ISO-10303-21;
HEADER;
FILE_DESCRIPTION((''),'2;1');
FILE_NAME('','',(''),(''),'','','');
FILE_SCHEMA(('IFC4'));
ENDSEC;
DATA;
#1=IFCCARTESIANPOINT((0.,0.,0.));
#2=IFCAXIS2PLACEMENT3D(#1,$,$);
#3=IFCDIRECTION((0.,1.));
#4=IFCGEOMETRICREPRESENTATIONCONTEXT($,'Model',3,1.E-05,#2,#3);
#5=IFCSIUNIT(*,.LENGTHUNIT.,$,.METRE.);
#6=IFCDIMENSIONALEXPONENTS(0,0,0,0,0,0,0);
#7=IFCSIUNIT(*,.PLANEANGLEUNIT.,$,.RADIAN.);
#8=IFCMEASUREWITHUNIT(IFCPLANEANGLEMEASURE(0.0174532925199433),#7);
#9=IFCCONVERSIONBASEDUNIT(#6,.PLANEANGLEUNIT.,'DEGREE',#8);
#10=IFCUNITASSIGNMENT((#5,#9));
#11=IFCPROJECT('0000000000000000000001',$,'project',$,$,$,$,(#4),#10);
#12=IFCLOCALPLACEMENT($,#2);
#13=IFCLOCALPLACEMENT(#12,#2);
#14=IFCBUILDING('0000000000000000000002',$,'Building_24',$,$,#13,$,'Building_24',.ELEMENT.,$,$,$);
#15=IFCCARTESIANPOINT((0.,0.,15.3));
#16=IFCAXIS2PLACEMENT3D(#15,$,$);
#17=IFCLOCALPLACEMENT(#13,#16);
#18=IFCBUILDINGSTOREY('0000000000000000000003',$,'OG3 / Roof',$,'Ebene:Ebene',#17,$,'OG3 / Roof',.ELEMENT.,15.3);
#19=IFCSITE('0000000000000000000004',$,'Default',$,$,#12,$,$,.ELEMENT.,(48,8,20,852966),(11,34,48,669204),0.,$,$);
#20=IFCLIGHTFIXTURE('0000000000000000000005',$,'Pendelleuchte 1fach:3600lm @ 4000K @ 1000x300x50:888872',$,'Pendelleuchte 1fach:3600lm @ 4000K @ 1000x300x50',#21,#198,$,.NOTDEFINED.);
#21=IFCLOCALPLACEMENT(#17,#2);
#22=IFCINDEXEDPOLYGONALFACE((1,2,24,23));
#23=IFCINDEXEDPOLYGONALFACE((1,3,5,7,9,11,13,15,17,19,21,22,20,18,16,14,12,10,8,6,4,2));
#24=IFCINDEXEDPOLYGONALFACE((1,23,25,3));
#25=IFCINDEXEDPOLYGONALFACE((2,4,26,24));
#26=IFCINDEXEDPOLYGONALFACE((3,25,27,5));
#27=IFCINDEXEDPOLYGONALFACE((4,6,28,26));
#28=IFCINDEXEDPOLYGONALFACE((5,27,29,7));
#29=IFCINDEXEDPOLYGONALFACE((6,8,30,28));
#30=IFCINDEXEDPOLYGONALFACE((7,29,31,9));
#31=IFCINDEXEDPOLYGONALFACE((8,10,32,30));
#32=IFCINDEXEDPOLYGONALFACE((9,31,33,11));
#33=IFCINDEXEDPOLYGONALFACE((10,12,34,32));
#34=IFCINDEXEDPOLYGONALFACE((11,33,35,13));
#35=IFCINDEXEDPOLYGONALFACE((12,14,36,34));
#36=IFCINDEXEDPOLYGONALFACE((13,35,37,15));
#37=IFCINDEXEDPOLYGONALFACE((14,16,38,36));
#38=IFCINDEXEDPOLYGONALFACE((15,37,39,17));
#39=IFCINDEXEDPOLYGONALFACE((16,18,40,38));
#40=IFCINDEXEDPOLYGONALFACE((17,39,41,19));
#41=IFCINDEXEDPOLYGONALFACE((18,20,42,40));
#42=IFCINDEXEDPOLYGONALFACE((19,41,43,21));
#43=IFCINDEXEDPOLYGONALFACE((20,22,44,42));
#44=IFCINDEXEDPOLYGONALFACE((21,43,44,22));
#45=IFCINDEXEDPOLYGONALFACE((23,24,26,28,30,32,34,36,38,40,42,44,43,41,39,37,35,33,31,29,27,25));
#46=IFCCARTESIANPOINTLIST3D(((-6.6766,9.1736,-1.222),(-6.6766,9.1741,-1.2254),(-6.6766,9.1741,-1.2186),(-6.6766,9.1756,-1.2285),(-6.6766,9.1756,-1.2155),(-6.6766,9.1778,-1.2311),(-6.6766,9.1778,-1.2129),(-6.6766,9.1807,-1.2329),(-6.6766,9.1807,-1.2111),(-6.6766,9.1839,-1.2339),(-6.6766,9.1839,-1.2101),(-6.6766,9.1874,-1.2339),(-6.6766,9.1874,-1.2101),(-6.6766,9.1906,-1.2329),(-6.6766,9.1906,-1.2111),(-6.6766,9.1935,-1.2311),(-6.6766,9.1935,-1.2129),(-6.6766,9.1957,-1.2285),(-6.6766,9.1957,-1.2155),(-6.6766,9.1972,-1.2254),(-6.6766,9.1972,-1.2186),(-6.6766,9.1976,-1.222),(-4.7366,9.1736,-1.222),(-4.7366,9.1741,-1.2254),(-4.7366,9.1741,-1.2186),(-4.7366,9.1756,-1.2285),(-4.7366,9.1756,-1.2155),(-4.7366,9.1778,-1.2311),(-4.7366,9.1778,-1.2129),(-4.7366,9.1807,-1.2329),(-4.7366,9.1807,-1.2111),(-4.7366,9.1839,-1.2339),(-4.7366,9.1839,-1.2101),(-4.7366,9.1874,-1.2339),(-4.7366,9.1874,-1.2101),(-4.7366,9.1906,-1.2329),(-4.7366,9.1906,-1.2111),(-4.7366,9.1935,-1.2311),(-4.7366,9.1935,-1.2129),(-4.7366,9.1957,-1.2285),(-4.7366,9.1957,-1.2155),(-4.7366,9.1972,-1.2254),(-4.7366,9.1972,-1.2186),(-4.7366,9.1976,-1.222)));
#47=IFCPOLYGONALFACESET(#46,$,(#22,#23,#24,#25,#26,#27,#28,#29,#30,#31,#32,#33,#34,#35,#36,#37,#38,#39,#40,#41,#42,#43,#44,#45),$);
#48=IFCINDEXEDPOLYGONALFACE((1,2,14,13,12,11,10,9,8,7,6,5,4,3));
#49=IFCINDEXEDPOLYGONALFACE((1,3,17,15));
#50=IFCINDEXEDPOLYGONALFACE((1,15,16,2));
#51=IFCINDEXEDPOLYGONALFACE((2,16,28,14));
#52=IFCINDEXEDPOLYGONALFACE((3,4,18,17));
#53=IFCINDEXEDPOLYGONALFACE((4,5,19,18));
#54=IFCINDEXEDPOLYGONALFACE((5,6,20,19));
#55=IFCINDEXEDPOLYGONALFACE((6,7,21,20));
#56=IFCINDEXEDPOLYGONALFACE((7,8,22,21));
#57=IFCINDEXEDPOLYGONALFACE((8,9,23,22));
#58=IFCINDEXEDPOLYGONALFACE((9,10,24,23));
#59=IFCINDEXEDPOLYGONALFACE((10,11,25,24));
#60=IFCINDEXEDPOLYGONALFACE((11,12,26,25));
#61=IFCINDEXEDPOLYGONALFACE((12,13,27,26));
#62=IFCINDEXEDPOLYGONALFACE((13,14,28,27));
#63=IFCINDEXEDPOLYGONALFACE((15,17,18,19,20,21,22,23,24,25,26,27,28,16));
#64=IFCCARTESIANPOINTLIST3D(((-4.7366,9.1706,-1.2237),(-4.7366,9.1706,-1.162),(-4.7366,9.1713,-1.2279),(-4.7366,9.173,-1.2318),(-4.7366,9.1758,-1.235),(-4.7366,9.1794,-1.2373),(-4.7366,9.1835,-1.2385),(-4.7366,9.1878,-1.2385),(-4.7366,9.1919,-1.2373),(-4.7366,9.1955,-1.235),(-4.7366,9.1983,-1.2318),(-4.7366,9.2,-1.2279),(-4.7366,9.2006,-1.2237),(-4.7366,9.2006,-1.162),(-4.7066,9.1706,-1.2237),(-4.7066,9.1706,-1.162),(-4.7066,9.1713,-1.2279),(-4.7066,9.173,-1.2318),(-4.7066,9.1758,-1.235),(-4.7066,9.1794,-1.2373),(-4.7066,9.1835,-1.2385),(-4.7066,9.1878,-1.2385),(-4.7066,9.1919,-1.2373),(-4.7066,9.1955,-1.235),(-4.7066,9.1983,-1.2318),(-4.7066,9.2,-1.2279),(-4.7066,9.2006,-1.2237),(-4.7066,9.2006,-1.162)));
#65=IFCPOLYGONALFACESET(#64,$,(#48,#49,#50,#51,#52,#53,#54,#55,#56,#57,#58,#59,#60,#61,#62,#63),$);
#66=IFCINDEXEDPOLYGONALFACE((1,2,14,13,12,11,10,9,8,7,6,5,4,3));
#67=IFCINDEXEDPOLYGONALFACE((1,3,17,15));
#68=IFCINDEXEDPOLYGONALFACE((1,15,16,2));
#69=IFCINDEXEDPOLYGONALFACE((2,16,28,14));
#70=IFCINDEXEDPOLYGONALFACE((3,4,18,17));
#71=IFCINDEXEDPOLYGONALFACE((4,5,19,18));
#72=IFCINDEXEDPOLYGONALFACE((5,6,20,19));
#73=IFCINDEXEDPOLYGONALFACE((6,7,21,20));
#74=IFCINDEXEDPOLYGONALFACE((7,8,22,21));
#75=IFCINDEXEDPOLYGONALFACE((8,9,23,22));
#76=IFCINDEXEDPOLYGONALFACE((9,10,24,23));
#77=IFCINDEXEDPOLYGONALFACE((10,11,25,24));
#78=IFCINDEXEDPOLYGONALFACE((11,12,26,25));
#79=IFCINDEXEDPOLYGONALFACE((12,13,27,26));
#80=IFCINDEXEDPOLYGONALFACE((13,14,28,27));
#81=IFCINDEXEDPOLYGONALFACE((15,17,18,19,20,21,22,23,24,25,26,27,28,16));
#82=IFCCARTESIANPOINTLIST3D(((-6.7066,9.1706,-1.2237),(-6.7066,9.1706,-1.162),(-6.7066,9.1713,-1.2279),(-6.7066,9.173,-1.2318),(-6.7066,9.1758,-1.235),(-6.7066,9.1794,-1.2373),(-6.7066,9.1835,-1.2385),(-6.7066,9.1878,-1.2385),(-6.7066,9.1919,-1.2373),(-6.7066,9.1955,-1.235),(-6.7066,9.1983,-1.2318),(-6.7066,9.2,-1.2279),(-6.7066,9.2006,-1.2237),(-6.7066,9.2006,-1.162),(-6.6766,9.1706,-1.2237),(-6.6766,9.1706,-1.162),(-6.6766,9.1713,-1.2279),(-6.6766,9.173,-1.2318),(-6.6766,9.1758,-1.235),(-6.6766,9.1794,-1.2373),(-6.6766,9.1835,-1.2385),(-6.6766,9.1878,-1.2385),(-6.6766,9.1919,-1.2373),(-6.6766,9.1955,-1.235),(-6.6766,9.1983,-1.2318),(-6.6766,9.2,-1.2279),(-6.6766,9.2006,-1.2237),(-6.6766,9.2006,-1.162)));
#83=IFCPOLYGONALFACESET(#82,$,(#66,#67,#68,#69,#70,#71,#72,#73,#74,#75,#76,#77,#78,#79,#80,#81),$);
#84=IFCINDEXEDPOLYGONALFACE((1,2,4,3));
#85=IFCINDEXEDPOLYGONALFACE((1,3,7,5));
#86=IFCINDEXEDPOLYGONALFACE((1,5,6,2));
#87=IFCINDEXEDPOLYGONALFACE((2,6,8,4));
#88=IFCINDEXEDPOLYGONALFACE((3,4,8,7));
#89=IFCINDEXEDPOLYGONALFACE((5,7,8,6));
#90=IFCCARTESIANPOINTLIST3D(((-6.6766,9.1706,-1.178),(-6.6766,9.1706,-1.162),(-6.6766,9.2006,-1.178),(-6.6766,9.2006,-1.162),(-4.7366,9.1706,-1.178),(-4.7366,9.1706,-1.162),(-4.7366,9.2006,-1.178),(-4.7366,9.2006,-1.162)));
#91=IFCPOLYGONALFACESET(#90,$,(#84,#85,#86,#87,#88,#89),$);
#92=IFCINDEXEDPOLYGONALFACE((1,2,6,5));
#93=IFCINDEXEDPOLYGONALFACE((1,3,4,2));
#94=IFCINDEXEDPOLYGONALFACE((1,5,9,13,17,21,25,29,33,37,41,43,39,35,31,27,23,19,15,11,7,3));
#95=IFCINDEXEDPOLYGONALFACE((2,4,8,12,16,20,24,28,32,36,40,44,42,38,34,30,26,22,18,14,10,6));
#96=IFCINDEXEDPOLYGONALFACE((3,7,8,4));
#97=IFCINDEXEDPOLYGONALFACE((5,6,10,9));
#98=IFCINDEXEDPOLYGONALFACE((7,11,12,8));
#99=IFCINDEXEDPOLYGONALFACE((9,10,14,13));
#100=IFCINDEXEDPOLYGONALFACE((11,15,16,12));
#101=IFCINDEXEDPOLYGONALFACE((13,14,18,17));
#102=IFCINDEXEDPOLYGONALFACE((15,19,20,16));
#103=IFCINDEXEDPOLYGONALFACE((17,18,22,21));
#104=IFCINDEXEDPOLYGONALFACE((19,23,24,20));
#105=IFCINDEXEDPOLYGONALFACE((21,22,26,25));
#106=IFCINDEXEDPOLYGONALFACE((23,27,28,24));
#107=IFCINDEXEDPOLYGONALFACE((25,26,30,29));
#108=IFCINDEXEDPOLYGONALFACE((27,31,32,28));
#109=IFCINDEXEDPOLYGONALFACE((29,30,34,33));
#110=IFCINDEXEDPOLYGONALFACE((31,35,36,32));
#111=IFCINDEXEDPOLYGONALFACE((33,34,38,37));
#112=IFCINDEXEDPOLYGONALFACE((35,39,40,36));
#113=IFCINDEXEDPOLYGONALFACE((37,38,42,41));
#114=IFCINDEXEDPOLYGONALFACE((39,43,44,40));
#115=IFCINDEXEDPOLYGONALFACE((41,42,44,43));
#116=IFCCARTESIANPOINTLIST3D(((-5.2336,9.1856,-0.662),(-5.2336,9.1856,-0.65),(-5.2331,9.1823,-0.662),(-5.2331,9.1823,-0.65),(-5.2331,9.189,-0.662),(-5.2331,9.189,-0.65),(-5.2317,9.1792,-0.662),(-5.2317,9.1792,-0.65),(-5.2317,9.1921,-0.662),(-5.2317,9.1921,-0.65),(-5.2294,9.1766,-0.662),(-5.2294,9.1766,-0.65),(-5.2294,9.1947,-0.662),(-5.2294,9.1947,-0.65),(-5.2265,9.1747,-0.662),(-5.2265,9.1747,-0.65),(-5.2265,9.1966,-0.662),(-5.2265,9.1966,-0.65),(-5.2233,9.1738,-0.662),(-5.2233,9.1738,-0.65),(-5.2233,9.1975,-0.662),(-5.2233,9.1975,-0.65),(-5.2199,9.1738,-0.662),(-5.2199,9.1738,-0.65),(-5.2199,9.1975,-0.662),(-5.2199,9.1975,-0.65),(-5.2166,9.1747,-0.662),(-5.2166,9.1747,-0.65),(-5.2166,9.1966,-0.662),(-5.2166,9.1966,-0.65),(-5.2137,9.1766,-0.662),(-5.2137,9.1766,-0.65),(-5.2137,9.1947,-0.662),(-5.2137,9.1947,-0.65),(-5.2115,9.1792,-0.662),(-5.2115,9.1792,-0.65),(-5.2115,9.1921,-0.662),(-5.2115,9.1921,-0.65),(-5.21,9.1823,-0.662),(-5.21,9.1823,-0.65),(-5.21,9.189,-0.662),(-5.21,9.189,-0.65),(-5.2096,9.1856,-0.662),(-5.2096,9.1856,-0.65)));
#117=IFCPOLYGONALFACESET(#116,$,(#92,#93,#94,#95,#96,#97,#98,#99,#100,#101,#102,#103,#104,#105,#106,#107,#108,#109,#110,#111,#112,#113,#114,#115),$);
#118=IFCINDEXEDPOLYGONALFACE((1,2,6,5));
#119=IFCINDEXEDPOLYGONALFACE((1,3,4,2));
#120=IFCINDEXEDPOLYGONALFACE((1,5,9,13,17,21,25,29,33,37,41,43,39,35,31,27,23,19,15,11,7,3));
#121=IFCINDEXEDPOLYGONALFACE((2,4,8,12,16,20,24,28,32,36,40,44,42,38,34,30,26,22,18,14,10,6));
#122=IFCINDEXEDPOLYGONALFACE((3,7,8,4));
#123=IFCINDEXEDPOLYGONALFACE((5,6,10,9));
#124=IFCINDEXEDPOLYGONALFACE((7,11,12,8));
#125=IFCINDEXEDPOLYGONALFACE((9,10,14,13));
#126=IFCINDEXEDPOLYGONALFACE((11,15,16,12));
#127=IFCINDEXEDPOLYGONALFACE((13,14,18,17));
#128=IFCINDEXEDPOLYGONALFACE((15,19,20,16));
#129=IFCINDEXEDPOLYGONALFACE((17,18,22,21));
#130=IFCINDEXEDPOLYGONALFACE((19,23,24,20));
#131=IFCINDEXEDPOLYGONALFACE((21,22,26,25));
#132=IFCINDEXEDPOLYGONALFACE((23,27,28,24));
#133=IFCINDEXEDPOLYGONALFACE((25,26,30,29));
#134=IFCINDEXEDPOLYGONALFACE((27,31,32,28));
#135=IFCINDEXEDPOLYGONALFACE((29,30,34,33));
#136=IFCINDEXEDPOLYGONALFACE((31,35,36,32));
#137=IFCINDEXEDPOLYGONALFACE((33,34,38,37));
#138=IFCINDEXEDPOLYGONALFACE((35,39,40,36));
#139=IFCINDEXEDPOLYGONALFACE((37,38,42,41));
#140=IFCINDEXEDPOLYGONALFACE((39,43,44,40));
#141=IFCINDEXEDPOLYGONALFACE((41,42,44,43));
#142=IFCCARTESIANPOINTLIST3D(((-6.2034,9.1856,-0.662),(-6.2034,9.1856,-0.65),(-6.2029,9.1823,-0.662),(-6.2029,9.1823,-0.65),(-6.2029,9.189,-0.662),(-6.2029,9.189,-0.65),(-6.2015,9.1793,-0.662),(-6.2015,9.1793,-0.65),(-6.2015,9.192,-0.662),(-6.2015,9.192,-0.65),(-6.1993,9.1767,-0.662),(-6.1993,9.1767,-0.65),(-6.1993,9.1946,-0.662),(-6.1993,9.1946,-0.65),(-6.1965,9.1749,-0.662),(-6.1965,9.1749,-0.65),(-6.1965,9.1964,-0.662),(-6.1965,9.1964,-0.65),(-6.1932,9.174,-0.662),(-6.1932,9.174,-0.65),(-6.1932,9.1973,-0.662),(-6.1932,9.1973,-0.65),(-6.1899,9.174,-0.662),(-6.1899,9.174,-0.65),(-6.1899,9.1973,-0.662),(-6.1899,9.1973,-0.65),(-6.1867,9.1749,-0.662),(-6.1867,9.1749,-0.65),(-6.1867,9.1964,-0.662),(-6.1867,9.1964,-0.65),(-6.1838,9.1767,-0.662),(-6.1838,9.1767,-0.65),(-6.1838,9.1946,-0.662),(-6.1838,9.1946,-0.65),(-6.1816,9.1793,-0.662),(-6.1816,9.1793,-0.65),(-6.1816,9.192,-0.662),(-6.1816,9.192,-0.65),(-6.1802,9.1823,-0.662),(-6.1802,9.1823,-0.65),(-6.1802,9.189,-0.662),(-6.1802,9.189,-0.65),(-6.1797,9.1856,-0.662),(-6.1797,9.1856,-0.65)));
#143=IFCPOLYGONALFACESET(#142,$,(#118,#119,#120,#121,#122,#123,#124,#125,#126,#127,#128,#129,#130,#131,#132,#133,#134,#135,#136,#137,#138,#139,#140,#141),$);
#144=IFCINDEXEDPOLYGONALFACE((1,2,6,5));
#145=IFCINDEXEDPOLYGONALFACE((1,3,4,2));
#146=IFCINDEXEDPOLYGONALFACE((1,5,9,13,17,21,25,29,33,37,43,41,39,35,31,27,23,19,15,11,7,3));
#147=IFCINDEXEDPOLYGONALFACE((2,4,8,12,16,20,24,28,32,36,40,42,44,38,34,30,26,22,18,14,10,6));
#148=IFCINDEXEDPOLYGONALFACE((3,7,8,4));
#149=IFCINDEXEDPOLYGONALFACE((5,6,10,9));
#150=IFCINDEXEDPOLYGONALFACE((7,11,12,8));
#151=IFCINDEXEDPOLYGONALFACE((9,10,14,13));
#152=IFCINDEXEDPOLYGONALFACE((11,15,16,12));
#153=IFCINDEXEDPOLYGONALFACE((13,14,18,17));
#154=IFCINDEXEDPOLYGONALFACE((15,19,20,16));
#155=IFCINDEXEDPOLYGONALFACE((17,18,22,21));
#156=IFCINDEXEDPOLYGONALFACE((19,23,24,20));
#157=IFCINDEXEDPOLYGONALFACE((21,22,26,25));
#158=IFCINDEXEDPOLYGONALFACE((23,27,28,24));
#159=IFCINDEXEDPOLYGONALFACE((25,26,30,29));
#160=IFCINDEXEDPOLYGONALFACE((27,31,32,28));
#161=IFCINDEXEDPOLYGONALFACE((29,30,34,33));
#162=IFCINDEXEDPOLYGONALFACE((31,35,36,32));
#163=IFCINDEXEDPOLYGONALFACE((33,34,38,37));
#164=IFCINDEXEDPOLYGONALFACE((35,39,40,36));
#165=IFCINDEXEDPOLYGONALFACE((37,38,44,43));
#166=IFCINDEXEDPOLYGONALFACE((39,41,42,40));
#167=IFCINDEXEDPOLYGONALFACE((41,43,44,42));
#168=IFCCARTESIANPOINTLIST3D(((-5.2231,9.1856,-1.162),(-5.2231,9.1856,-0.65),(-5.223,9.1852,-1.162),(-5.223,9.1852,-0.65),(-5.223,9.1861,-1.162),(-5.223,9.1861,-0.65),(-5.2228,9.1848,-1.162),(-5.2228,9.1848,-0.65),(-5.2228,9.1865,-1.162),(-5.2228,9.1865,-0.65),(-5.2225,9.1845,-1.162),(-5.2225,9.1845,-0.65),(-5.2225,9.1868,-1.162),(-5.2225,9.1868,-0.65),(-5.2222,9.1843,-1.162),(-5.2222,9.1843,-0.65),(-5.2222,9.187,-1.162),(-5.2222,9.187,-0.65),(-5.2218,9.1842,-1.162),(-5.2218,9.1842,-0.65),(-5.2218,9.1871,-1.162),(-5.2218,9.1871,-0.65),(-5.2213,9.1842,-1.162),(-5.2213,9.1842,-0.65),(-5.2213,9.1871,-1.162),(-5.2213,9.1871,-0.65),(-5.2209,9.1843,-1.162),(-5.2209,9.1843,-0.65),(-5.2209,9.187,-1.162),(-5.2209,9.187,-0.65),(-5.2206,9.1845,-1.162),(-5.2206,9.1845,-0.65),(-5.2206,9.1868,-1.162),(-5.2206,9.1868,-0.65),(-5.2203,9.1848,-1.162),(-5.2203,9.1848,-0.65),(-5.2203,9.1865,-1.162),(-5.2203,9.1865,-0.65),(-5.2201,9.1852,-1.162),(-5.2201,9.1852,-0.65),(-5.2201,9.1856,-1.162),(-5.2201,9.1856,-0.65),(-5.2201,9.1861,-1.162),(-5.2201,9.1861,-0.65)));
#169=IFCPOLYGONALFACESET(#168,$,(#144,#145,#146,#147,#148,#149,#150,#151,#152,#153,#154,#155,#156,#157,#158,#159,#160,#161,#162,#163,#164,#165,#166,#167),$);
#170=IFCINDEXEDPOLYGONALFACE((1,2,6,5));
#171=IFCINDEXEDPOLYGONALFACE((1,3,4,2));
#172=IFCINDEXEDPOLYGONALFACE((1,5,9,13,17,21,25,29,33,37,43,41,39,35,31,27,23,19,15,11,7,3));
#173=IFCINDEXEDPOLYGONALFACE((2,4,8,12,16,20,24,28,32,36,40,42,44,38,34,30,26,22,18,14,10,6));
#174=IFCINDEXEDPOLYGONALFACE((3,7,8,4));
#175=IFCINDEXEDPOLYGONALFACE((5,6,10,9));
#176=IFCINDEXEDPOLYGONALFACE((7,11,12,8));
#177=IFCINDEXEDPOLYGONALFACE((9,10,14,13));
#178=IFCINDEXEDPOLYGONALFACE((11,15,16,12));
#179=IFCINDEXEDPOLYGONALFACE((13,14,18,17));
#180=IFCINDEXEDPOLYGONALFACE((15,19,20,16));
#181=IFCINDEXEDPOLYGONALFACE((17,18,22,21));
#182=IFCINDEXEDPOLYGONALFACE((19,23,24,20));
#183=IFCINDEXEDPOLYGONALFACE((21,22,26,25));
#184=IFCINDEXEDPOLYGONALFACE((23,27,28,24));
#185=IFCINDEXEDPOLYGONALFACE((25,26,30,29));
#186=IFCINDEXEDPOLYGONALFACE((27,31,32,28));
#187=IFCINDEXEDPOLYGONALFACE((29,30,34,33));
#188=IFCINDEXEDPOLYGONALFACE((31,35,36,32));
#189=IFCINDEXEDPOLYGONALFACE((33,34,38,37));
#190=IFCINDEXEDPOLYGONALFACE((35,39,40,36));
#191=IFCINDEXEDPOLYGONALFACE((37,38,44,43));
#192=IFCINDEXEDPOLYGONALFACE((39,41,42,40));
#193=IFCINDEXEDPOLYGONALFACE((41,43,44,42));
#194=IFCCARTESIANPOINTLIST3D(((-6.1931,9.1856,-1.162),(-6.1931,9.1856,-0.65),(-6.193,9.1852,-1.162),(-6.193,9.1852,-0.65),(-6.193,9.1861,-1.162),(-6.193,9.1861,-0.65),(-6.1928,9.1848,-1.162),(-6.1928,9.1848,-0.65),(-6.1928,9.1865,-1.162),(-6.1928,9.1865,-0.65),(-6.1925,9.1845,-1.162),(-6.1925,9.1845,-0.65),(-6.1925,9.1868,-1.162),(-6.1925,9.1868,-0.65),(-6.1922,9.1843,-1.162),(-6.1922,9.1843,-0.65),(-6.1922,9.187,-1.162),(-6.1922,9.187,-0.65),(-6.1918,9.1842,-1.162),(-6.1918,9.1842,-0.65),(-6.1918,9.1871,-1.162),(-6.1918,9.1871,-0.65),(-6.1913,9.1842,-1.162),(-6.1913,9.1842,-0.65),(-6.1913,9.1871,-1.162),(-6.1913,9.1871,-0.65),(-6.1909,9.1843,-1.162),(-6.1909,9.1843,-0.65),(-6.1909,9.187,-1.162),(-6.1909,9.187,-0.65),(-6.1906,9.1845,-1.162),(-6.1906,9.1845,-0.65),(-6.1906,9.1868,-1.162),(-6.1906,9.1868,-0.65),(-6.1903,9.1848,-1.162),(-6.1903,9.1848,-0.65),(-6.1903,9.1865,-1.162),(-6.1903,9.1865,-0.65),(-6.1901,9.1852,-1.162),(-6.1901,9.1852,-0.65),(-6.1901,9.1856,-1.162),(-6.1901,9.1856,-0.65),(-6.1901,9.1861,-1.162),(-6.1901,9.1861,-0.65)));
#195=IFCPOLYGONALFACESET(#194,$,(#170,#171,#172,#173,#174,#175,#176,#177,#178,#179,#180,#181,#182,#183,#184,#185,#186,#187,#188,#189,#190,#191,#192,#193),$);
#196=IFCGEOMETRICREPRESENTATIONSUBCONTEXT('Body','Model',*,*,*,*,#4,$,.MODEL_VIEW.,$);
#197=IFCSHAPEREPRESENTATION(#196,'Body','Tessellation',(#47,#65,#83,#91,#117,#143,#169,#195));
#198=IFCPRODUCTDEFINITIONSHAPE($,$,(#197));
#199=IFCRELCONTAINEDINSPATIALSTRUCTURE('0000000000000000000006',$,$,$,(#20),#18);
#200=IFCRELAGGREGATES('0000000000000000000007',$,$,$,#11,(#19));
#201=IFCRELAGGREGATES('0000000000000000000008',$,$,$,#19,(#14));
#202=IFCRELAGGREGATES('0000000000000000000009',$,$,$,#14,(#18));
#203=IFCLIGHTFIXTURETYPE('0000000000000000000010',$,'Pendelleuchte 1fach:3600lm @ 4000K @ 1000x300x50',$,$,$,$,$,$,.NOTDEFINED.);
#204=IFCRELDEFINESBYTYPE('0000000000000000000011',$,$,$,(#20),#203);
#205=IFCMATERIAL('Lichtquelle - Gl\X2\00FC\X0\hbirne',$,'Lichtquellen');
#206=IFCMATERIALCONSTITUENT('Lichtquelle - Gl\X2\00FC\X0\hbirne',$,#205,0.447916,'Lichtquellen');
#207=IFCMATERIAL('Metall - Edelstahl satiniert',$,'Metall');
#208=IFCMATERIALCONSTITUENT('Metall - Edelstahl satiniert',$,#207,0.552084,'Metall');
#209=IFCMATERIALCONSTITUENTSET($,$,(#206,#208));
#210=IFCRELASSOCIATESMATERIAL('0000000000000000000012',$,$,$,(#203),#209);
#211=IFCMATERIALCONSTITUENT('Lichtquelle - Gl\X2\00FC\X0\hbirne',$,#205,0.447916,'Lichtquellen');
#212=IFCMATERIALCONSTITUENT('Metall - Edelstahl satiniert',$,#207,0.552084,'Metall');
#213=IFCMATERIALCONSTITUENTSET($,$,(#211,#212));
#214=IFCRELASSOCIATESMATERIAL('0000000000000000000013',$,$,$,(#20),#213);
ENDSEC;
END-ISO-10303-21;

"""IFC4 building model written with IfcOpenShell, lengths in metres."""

from ifc_helpers import new_model, entity, si_unit, converted_unit, direction, frame, origin, place, context, subcontext, project, spatial, line, arc, indexed_curve, outline, extrude, source, transform, mapped, material, constituent, constituent_set, type_object, type_shapes, element, save


model = new_model("IFC4")

# Units and contexts
model_context = context("Model", 3, precision=1e-05, world=origin(), true_north=direction((0.0, 1.0)))
body_context = subcontext(model_context, "Body", "Model", "MODEL_VIEW")
ifc_project = project(units=[si_unit("LENGTHUNIT", "METRE"), converted_unit("PLANEANGLEUNIT", "DEGREE", entity("IfcPlaneAngleMeasure", 0.0174532925199433), si_unit("PLANEANGLEUNIT", "RADIAN"), dimensions=[0, 0, 0, 0, 0, 0, 0])], contexts=[model_context])

# Site, building, storey
site_placement = place(None, origin())
site = spatial("IfcSite", under=ifc_project, at=site_placement, Name="Default", CompositionType="ELEMENT", RefLatitude=(48, 8, 20, 852966), RefLongitude=(11, 34, 48, 669204), RefElevation=0.0)
building_placement = place(site_placement, origin())
building = spatial("IfcBuilding", under=site, at=building_placement, Name="Building_24", LongName="Building_24", CompositionType="ELEMENT")
storey_placement = place(building_placement, frame((0.0, 0.0, 15.3)))
storey = spatial("IfcBuildingStorey", under=building, at=storey_placement, Name="OG3 / Roof", ObjectType="Ebene:Ebene", LongName="OG3 / Roof", CompositionType="ELEMENT", Elevation=15.3)

# Light fixture
ifc_material_1 = material(Name="Lichtquelle - Glühbirne", Category="Lichtquellen")
ifc_material_2 = material(Name="Metall - Edelstahl satiniert", Category="Metall")
ifc_constituent_1 = constituent(ifc_material_1, Name="Lichtquelle - Glühbirne", Category="Lichtquellen", fraction=0.447916)
ifc_constituent_2 = constituent(ifc_material_2, Name="Metall - Edelstahl satiniert", Category="Metall", fraction=0.552084)
ifc_constituent_set_1 = constituent_set(constituents=[ifc_constituent_1, ifc_constituent_2])
light_fixture_type_1 = type_object("IfcLightFixtureType", Name="Pendelleuchte 1fach:3600lm @ 4000K @ 1000x300x50", PredefinedType="NOTDEFINED", material=ifc_constituent_set_1)
shared_shape_1 = source(origin(), body_context, "Body", "SweptSolid", [
    extrude(outline(indexed_curve([(-0.012, 0.0), (0.0, -0.012), (0.012, 0.0), (0.0, 0.012)], segments=[arc(1, 2, 3), arc(3, 4, 1)], self_intersect=False)), frame((-0.97, 0.0, -0.572), z_axis=(1.0, 0.0, 0.0), x_axis=(0.0, 1.0, 0.0)), (0.0, 0.0, 1.0), 1.94),
    extrude(outline(indexed_curve([(-0.0308, -0.015), (0.0308, -0.015), (0.0308, 0.015), (-0.0308, 0.015), (-0.0458, 0.0)], segments=[line(1, 2, 3, 4), arc(4, 5, 1)], self_intersect=False)), frame((0.97, 0.0, -0.5428), z_axis=(1.0, 0.0, 0.0), x_axis=(0.0, 0.0, 1.0)), (0.0, 0.0, 1.0), 0.03),
    extrude(outline(indexed_curve([(-0.0308, -0.015), (0.0308, -0.015), (0.0308, 0.015), (-0.0308, 0.015), (-0.0458, 0.0)], segments=[line(1, 2, 3, 4), arc(4, 5, 1)], self_intersect=False)), frame((-1.0, 0.0, -0.5428), z_axis=(1.0, 0.0, 0.0), x_axis=(0.0, 0.0, 1.0)), (0.0, 0.0, 1.0), 0.03),
    extrude(outline(indexed_curve([(-0.97, -0.015), (0.97, -0.015), (0.97, 0.015), (-0.97, 0.015), (-0.97, -0.015)], self_intersect=False)), frame((0.0, 0.0, -0.528), z_axis=(0.0, 0.0, 1.0), x_axis=(-1.0, 0.0, 0.0)), (0.0, 0.0, 1.0), 0.016),
    extrude(outline(indexed_curve([(-0.012, 0.0), (0.0, -0.012), (0.012, 0.0), (0.0, 0.012)], segments=[arc(1, 2, 3), arc(3, 4, 1)], self_intersect=False)), frame((0.485, 0.0, -0.012)), (0.0, 0.0, 1.0), 0.012),
    extrude(outline(indexed_curve([(-0.0118, 0.0), (0.0, -0.0118), (0.0118, 0.0), (0.0, 0.0118)], segments=[arc(1, 2, 3), arc(3, 4, 1)], self_intersect=False)), frame((-0.485, 0.0, -0.012)), (0.0, 0.0, 1.0), 0.012),
    extrude(outline(indexed_curve([(-0.0015, 0.0), (0.0, -0.0015), (0.0015, 0.0), (0.0, 0.0015)], segments=[arc(1, 2, 3), arc(3, 4, 1)], self_intersect=False)), frame((0.485, 0.0, -0.512)), (0.0, 0.0, 1.0), 0.512),
    extrude(outline(indexed_curve([(-0.0015, 0.0), (0.0, -0.0015), (0.0015, 0.0), (0.0, 0.0015)], segments=[arc(1, 2, 3), arc(3, 4, 1)], self_intersect=False)), frame((-0.485, 0.0, -0.512)), (0.0, 0.0, 1.0), 0.512),
])
type_shapes(light_fixture_type_1, [shared_shape_1])
ifc_constituent_3 = constituent(ifc_material_1, Name="Lichtquelle - Glühbirne", Category="Lichtquellen", fraction=0.447916)
ifc_constituent_4 = constituent(ifc_material_2, Name="Metall - Edelstahl satiniert", Category="Metall", fraction=0.552084)
ifc_constituent_set_2 = constituent_set(constituents=[ifc_constituent_3, ifc_constituent_4])
light_fixture_1_placement = place(storey_placement, frame((-5.7066, 9.1856, -0.65)))
element("IfcLightFixture", 1, at=light_fixture_1_placement, inside=storey, type_object=light_fixture_type_1, material=ifc_constituent_set_2, Name="Pendelleuchte 1fach:3600lm @ 4000K @ 1000x300x50:888872", ObjectType="Pendelleuchte 1fach:3600lm @ 4000K @ 1000x300x50", PredefinedType="NOTDEFINED", context=body_context, shape_type="MappedRepresentation", body=[
    mapped(shared_shape_1, transform((0.0, 0.0, 0.0), scale=1.0)),
])

save(model, "model.ifc")
